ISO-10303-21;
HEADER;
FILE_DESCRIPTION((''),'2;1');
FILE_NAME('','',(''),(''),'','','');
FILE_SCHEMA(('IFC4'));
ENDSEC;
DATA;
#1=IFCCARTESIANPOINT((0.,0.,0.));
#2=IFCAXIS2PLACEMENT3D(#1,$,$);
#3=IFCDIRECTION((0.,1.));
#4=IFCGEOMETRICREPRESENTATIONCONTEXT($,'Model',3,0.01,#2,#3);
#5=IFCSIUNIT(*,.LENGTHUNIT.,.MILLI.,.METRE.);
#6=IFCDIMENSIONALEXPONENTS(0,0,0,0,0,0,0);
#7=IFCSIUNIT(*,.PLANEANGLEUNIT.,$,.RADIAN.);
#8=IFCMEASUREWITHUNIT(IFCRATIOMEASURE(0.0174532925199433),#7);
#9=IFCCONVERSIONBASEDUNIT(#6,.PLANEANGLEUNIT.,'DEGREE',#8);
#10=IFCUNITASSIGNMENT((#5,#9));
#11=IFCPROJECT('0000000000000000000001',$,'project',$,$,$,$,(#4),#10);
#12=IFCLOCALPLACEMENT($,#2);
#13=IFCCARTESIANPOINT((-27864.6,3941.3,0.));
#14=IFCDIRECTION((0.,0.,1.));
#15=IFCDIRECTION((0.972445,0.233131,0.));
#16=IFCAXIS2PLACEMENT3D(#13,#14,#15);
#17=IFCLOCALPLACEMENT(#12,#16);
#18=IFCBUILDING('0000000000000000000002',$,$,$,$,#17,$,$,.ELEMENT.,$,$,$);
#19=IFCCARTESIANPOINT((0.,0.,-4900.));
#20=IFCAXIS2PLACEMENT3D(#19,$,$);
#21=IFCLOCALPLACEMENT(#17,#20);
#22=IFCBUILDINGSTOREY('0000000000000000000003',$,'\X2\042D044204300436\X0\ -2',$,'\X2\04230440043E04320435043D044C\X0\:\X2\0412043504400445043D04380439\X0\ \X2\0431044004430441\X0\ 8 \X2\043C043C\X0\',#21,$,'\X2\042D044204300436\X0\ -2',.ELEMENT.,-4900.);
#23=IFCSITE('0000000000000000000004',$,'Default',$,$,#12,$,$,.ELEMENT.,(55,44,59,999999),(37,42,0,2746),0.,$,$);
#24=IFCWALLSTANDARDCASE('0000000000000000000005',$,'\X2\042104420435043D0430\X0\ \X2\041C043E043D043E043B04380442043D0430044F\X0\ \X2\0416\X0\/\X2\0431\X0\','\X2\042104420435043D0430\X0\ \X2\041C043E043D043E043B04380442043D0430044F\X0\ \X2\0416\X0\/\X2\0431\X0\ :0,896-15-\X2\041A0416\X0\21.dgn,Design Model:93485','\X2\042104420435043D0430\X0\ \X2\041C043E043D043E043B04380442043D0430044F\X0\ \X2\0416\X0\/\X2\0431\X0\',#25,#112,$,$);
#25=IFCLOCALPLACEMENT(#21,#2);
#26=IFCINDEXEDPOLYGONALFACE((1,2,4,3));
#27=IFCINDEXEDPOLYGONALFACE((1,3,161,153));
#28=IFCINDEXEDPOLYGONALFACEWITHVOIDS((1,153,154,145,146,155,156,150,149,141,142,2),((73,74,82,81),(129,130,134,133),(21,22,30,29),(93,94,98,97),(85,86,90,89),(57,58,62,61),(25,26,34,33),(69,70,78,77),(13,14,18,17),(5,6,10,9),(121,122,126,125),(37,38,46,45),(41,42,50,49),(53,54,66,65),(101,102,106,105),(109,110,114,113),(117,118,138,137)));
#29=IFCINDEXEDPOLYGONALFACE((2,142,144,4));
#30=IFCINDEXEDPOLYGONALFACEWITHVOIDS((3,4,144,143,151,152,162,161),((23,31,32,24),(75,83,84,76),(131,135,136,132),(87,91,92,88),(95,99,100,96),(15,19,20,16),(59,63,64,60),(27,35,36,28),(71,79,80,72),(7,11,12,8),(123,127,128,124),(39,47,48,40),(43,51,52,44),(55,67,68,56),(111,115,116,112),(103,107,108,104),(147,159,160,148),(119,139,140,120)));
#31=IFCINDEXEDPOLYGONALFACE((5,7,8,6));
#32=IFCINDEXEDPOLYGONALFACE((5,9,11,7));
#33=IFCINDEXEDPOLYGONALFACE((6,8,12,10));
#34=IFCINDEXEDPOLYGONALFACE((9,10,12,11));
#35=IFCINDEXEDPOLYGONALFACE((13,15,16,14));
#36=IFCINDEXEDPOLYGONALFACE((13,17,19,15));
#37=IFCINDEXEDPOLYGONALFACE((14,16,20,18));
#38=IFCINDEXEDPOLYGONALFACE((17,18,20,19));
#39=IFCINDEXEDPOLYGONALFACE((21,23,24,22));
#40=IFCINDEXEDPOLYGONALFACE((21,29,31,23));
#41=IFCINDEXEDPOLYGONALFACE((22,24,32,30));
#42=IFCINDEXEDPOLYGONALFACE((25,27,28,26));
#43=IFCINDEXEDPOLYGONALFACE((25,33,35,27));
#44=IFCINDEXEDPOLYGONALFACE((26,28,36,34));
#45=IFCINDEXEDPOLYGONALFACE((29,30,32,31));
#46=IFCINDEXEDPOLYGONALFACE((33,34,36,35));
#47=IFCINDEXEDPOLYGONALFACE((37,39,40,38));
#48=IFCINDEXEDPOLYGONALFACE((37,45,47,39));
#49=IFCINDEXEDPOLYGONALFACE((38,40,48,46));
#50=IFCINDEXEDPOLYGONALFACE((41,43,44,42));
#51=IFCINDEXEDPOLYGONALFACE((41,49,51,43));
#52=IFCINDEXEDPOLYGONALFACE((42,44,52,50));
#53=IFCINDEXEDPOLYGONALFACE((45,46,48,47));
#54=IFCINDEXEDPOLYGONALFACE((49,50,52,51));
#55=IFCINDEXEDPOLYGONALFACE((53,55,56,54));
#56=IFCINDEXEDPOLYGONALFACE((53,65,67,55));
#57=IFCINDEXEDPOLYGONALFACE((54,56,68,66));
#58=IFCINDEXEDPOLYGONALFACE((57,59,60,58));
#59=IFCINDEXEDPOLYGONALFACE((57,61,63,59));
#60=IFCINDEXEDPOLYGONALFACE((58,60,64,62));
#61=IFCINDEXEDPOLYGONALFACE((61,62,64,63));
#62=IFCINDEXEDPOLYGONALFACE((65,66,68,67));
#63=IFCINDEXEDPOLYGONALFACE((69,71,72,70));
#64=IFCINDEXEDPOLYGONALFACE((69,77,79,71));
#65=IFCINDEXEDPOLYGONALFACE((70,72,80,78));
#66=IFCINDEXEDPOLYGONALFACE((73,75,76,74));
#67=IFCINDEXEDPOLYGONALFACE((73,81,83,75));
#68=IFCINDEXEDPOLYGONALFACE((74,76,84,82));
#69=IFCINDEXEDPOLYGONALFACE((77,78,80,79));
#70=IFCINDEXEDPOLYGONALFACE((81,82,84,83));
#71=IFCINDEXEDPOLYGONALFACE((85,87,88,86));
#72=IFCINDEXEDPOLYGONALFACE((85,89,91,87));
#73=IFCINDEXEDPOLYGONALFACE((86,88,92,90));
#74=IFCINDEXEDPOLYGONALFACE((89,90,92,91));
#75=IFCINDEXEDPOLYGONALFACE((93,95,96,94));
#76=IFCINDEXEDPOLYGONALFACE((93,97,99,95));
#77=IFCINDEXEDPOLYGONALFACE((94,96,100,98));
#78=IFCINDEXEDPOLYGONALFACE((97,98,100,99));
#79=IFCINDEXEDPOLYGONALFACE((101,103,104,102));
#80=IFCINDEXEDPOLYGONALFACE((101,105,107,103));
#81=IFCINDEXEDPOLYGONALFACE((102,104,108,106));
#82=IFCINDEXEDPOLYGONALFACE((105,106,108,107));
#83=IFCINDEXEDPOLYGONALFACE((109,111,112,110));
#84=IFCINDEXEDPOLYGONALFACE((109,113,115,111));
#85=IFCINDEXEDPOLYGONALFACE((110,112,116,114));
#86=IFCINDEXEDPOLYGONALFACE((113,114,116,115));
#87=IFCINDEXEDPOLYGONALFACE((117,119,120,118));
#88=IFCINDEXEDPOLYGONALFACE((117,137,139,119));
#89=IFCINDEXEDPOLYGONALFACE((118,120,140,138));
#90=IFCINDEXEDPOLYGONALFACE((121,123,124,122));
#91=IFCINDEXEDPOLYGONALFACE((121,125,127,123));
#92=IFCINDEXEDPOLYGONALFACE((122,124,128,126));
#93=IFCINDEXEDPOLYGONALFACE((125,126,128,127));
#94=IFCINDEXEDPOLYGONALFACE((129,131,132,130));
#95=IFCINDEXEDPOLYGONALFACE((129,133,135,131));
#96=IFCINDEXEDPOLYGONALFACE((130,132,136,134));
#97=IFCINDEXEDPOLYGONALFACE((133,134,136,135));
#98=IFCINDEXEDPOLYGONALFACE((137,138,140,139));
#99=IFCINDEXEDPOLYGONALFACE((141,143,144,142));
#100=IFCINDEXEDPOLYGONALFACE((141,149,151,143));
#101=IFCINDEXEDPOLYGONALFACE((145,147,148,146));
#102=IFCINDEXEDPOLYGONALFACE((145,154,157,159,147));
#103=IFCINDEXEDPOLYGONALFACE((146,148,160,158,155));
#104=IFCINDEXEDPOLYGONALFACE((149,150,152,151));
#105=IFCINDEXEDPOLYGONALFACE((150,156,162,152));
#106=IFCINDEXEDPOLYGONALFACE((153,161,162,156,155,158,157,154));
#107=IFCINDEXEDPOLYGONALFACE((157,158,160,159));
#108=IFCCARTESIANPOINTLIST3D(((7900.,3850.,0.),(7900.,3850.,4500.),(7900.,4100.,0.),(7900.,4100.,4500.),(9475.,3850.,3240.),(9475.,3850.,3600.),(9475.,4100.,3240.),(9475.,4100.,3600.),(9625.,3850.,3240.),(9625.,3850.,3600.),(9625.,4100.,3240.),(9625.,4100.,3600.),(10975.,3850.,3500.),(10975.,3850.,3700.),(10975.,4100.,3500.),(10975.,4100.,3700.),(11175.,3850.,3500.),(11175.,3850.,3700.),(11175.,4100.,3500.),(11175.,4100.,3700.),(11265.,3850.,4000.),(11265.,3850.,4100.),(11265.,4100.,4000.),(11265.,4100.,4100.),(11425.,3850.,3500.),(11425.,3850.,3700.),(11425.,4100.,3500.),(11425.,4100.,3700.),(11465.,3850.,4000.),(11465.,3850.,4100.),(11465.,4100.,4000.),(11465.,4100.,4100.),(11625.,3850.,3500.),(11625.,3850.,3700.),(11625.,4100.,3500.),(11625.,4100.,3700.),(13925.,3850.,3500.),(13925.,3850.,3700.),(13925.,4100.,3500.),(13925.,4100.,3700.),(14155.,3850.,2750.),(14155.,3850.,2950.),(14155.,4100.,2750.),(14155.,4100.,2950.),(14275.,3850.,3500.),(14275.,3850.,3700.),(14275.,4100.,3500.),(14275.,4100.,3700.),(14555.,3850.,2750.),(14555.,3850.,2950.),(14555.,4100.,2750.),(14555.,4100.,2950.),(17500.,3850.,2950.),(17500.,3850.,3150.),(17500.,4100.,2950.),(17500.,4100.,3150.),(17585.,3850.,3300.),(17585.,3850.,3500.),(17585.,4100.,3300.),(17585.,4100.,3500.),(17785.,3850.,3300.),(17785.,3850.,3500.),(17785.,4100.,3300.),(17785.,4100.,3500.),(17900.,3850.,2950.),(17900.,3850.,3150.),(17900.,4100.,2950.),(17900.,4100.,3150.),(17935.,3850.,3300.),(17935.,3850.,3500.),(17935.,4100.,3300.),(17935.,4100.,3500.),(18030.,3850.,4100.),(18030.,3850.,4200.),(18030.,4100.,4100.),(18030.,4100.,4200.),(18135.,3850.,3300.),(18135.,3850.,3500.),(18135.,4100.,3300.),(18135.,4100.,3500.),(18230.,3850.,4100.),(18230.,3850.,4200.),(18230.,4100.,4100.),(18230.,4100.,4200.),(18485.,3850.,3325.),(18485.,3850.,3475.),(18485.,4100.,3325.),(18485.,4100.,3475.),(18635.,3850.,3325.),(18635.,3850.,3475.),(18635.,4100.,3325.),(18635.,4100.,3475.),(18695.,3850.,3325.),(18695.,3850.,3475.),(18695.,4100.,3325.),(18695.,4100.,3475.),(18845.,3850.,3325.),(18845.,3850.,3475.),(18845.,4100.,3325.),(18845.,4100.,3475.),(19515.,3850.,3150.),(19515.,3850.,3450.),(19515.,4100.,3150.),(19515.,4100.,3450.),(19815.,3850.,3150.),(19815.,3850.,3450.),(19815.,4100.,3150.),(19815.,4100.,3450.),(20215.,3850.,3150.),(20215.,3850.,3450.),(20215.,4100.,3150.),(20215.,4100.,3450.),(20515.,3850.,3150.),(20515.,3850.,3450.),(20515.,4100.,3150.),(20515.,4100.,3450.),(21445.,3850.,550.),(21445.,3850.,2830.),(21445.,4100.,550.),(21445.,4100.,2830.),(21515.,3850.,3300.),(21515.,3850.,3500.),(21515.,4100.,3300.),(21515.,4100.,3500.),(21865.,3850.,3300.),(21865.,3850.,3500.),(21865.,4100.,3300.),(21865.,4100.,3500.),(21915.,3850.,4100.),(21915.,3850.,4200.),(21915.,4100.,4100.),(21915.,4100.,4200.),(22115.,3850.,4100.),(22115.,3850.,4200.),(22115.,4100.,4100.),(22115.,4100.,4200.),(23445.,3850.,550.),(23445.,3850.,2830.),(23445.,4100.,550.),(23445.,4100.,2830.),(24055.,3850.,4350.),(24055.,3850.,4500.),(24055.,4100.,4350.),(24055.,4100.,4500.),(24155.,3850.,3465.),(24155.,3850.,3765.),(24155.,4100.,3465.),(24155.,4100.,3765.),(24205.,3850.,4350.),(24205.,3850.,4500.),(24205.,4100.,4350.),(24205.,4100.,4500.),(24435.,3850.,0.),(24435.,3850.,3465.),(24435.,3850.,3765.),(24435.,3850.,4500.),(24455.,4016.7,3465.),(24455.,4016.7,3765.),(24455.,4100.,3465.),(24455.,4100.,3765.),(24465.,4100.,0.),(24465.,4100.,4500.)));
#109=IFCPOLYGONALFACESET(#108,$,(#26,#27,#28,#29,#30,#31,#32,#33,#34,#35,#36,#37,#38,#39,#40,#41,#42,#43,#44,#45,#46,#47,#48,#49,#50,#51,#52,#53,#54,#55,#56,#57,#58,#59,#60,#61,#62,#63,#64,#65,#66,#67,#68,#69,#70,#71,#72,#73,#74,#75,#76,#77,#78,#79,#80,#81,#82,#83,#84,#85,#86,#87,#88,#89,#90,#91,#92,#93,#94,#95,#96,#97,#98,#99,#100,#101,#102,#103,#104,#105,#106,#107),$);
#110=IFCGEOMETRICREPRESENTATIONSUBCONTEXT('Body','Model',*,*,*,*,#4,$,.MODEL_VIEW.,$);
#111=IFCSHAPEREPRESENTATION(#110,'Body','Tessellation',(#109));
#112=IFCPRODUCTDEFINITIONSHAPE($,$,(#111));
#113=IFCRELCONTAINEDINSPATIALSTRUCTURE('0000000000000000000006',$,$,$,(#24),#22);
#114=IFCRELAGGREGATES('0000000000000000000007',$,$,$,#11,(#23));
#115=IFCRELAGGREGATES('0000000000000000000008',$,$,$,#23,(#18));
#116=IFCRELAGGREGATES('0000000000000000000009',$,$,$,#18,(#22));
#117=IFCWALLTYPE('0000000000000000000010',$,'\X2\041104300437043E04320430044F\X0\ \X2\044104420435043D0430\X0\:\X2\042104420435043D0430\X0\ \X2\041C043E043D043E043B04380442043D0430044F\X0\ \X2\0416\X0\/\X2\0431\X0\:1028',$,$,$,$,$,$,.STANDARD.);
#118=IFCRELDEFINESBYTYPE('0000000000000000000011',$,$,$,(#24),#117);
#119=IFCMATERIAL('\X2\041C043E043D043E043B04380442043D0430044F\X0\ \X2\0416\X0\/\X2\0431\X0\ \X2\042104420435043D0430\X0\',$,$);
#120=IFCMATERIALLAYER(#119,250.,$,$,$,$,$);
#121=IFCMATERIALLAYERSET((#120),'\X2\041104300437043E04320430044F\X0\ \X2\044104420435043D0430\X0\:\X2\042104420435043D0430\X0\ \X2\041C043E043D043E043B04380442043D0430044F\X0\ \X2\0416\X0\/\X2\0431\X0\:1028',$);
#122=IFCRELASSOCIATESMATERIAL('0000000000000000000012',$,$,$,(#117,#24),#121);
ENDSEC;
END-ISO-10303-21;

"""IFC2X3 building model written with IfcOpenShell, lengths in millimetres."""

from ifc_helpers import new_model, entity, si_unit, converted_unit, direction, frame, origin, origin_2d_with_axis, place, context, subcontext, project, spatial, polyline, rectangle, outline, extrude, material, layer, layer_set, layer_usage, type_object, element, save


model = new_model("IFC2X3")

# Units and contexts
model_context = context("Model", 3, precision=0.01, world=origin(), true_north=direction((0.0, 1.0)))
body_context = subcontext(model_context, "Body", "Model", "MODEL_VIEW")
ifc_project = project(units=[si_unit("LENGTHUNIT", "METRE", prefix="MILLI"), converted_unit("PLANEANGLEUNIT", "DEGREE", entity("IfcRatioMeasure", 0.0174532925199433), si_unit("PLANEANGLEUNIT", "RADIAN"), dimensions=[0, 0, 0, 0, 0, 0, 0])], contexts=[model_context])

# Site, building, storey
site_placement = place(None, origin())
site = spatial("IfcSite", under=ifc_project, at=site_placement, Name="Default", CompositionType="ELEMENT", RefLatitude=(55, 44, 59, 999999), RefLongitude=(37, 42, 0, 2746), RefElevation=0.0)
building_placement = place(site_placement, frame((-27864.6, 3941.3, 0.0), z_axis=(0.0, 0.0, 1.0), x_axis=(0.972445, 0.233131, 0.0)))
building = spatial("IfcBuilding", under=site, at=building_placement, CompositionType="ELEMENT")
storey_placement = place(building_placement, frame((0.0, 0.0, -4900.0)))
storey = spatial("IfcBuildingStorey", under=building, at=storey_placement, Name="Этаж -2", ObjectType="Уровень:Верхний брус 8 мм", LongName="Этаж -2", CompositionType="ELEMENT", Elevation=-4900.0)

# Shared definitions
ifc_material = material(Name="Монолитная Ж/б Стена")

# Wall, openings
ifc_layer_1 = layer(ifc_material, 250.0)
ifc_layer_set_1 = layer_set([ifc_layer_1], Name="Базовая стена:Стена Монолитная Ж/б:1028")
ifc_layer_usage_1 = layer_usage(ifc_layer_set_1, "AXIS2", "NEGATIVE", 125.0)
wall_type_1 = type_object("IfcWallType", Name="Базовая стена:Стена Монолитная Ж/б:1028", PredefinedType="STANDARD", material=ifc_layer_set_1)
wall_1_placement = place(storey_placement, frame((24465.0, 3975.0, 0.0), z_axis=(0.0, 0.0, 1.0), x_axis=(-1.0, 0.0, 0.0)))
wall_1 = element("IfcWallStandardCase", 1, at=wall_1_placement, inside=storey, type_object=wall_type_1, material=ifc_layer_usage_1, Name="Стена Монолитная Ж/б", Description="Стена Монолитная Ж/б :0,896-15-КЖ21.dgn,Design Model:93485", ObjectType="Стена Монолитная Ж/б", context=body_context, shape_type="SweptSolid", body=[
    extrude(outline(polyline([(16565.0, -125.0), (16565.0, 125.0), (30.0, 125.0), (0.0, -125.0), (16565.0, -125.0)])), origin(), (0.0, 0.0, 1.0), 4500.0),
])
placement = place(wall_1_placement, origin())
element("IfcOpeningElement", 2, at=placement, cuts=wall_1, ObjectType="Opening", context=body_context, shape_type="SweptSolid", body=[
    extrude(rectangle(XDim=2280.0, YDim=2000.0, at=origin_2d_with_axis()), frame((2020.0, -125.0, 1690.0), z_axis=(0.0, 1.0, 0.0), x_axis=(0.0, 0.0, -1.0)), (0.0, 0.0, 1.0), 250.0),
])
element("IfcOpeningElement", 3, at=placement, cuts=wall_1, ObjectType="Opening", context=body_context, shape_type="SweptSolid", body=[
    extrude(rectangle(XDim=360.0, YDim=150.0, at=origin_2d_with_axis()), frame((14915.0, -125.0, 3420.0), z_axis=(0.0, 1.0, 0.0), x_axis=(0.0, 0.0, -1.0)), (0.0, 0.0, 1.0), 250.0),
])
element("IfcOpeningElement", 4, at=placement, cuts=wall_1, ObjectType="Opening", context=body_context, shape_type="SweptSolid", body=[
    extrude(rectangle(XDim=200.0, YDim=200.0, at=origin_2d_with_axis()), frame((13390.0, -125.0, 3600.0), z_axis=(0.0, 1.0, 0.0), x_axis=(0.0, 0.0, -1.0)), (0.0, 0.0, 1.0), 250.0),
])
element("IfcOpeningElement", 5, at=placement, cuts=wall_1, ObjectType="Opening", context=body_context, shape_type="SweptSolid", body=[
    extrude(rectangle(XDim=200.0, YDim=200.0, at=origin_2d_with_axis()), frame((12940.0, -125.0, 3600.0), z_axis=(0.0, 1.0, 0.0), x_axis=(0.0, 0.0, -1.0)), (0.0, 0.0, 1.0), 250.0),
])
element("IfcOpeningElement", 6, at=placement, cuts=wall_1, ObjectType="Opening", context=body_context, shape_type="SweptSolid", body=[
    extrude(rectangle(XDim=200.0, YDim=350.0, at=origin_2d_with_axis()), frame((10365.0, -125.0, 3600.0), z_axis=(0.0, 1.0, 0.0), x_axis=(0.0, 0.0, -1.0)), (0.0, 0.0, 1.0), 250.0),
])
element("IfcOpeningElement", 7, at=placement, cuts=wall_1, ObjectType="Opening", context=body_context, shape_type="SweptSolid", body=[
    extrude(rectangle(XDim=100.0, YDim=200.0, at=origin_2d_with_axis()), frame((13100.0, -125.0, 4050.0), z_axis=(0.0, 1.0, 0.0), x_axis=(0.0, 0.0, -1.0)), (0.0, 0.0, 1.0), 250.0),
])
element("IfcOpeningElement", 8, at=placement, cuts=wall_1, ObjectType="Opening", context=body_context, shape_type="SweptSolid", body=[
    extrude(rectangle(XDim=200.0, YDim=400.0, at=origin_2d_with_axis()), frame((10110.0, -125.0, 2850.0), z_axis=(0.0, 1.0, 0.0), x_axis=(0.0, 0.0, -1.0)), (0.0, 0.0, 1.0), 250.0),
])
element("IfcOpeningElement", 9, at=placement, cuts=wall_1, ObjectType="Opening", context=body_context, shape_type="SweptSolid", body=[
    extrude(rectangle(XDim=200.0, YDim=200.0, at=origin_2d_with_axis()), frame((6780.0, -125.0, 3400.0), z_axis=(0.0, 1.0, 0.0), x_axis=(0.0, 0.0, -1.0)), (0.0, 0.0, 1.0), 250.0),
])
element("IfcOpeningElement", 10, at=placement, cuts=wall_1, ObjectType="Opening", context=body_context, shape_type="SweptSolid", body=[
    extrude(rectangle(XDim=200.0, YDim=200.0, at=origin_2d_with_axis()), frame((6430.0, -125.0, 3400.0), z_axis=(0.0, 1.0, 0.0), x_axis=(0.0, 0.0, -1.0)), (0.0, 0.0, 1.0), 250.0),
])
element("IfcOpeningElement", 11, at=placement, cuts=wall_1, ObjectType="Opening", context=body_context, shape_type="SweptSolid", body=[
    extrude(rectangle(XDim=150.0, YDim=150.0, at=origin_2d_with_axis()), frame((5905.0, -125.0, 3400.0), z_axis=(0.0, 1.0, 0.0), x_axis=(0.0, 0.0, -1.0)), (0.0, 0.0, 1.0), 250.0),
])
element("IfcOpeningElement", 12, at=placement, cuts=wall_1, ObjectType="Opening", context=body_context, shape_type="SweptSolid", body=[
    extrude(rectangle(XDim=150.0, YDim=150.0, at=origin_2d_with_axis()), frame((5695.0, -125.0, 3400.0), z_axis=(0.0, 1.0, 0.0), x_axis=(0.0, 0.0, -1.0)), (0.0, 0.0, 1.0), 250.0),
])
element("IfcOpeningElement", 13, at=placement, cuts=wall_1, ObjectType="Opening", context=body_context, shape_type="SweptSolid", body=[
    extrude(rectangle(XDim=300.0, YDim=300.0, at=origin_2d_with_axis()), frame((4800.0, -125.0, 3300.0), z_axis=(0.0, 1.0, 0.0), x_axis=(0.0, 0.0, -1.0)), (0.0, 0.0, 1.0), 250.0),
])
element("IfcOpeningElement", 14, at=placement, cuts=wall_1, ObjectType="Opening", context=body_context, shape_type="SweptSolid", body=[
    extrude(rectangle(XDim=300.0, YDim=300.0, at=origin_2d_with_axis()), frame((4100.0, -125.0, 3300.0), z_axis=(0.0, 1.0, 0.0), x_axis=(0.0, 0.0, -1.0)), (0.0, 0.0, 1.0), 250.0),
])
element("IfcOpeningElement", 15, at=placement, cuts=wall_1, ObjectType="Opening", context=body_context, shape_type="SweptSolid", body=[
    extrude(rectangle(XDim=200.0, YDim=350.0, at=origin_2d_with_axis()), frame((2775.0, -125.0, 3400.0), z_axis=(0.0, 1.0, 0.0), x_axis=(0.0, 0.0, -1.0)), (0.0, 0.0, 1.0), 250.0),
])
element("IfcOpeningElement", 16, at=placement, cuts=wall_1, ObjectType="Opening", context=body_context, shape_type="SweptSolid", body=[
    extrude(rectangle(XDim=300.0, YDim=300.0, at=origin_2d_with_axis()), frame((160.0, -125.0, 3615.0), z_axis=(0.0, 1.0, 0.0), x_axis=(0.0, 0.0, -1.0)), (0.0, 0.0, 1.0), 250.0),
])
element("IfcOpeningElement", 17, at=placement, cuts=wall_1, ObjectType="Opening", context=body_context, shape_type="SweptSolid", body=[
    extrude(rectangle(XDim=200.0, YDim=400.0, at=origin_2d_with_axis()), frame((6765.0, -125.0, 3050.0), z_axis=(0.0, 1.0, 0.0), x_axis=(0.0, 0.0, -1.0)), (0.0, 0.0, 1.0), 250.0),
])
element("IfcOpeningElement", 18, at=placement, cuts=wall_1, ObjectType="Opening", context=body_context, shape_type="SweptSolid", body=[
    extrude(rectangle(XDim=100.0, YDim=200.0, at=origin_2d_with_axis()), frame((6335.0, -125.0, 4150.0), z_axis=(0.0, 1.0, 0.0), x_axis=(0.0, 0.0, -1.0)), (0.0, 0.0, 1.0), 250.0),
])
element("IfcOpeningElement", 19, at=placement, cuts=wall_1, ObjectType="Opening", context=body_context, shape_type="SweptSolid", body=[
    extrude(rectangle(XDim=100.0, YDim=200.0, at=origin_2d_with_axis()), frame((2450.0, -125.0, 4150.0), z_axis=(0.0, 1.0, 0.0), x_axis=(0.0, 0.0, -1.0)), (0.0, 0.0, 1.0), 250.0),
])
element("IfcOpeningElement", 20, at=placement, cuts=wall_1, ObjectType="Opening", context=body_context, shape_type="SweptSolid", body=[
    extrude(rectangle(XDim=150.0, YDim=150.0, at=origin_2d_with_axis()), frame((335.0, -125.0, 4425.0), z_axis=(0.0, 1.0, 0.0), x_axis=(0.0, 0.0, -1.0)), (0.0, 0.0, 1.0), 250.0),
])

save(model, "model.ifc")
